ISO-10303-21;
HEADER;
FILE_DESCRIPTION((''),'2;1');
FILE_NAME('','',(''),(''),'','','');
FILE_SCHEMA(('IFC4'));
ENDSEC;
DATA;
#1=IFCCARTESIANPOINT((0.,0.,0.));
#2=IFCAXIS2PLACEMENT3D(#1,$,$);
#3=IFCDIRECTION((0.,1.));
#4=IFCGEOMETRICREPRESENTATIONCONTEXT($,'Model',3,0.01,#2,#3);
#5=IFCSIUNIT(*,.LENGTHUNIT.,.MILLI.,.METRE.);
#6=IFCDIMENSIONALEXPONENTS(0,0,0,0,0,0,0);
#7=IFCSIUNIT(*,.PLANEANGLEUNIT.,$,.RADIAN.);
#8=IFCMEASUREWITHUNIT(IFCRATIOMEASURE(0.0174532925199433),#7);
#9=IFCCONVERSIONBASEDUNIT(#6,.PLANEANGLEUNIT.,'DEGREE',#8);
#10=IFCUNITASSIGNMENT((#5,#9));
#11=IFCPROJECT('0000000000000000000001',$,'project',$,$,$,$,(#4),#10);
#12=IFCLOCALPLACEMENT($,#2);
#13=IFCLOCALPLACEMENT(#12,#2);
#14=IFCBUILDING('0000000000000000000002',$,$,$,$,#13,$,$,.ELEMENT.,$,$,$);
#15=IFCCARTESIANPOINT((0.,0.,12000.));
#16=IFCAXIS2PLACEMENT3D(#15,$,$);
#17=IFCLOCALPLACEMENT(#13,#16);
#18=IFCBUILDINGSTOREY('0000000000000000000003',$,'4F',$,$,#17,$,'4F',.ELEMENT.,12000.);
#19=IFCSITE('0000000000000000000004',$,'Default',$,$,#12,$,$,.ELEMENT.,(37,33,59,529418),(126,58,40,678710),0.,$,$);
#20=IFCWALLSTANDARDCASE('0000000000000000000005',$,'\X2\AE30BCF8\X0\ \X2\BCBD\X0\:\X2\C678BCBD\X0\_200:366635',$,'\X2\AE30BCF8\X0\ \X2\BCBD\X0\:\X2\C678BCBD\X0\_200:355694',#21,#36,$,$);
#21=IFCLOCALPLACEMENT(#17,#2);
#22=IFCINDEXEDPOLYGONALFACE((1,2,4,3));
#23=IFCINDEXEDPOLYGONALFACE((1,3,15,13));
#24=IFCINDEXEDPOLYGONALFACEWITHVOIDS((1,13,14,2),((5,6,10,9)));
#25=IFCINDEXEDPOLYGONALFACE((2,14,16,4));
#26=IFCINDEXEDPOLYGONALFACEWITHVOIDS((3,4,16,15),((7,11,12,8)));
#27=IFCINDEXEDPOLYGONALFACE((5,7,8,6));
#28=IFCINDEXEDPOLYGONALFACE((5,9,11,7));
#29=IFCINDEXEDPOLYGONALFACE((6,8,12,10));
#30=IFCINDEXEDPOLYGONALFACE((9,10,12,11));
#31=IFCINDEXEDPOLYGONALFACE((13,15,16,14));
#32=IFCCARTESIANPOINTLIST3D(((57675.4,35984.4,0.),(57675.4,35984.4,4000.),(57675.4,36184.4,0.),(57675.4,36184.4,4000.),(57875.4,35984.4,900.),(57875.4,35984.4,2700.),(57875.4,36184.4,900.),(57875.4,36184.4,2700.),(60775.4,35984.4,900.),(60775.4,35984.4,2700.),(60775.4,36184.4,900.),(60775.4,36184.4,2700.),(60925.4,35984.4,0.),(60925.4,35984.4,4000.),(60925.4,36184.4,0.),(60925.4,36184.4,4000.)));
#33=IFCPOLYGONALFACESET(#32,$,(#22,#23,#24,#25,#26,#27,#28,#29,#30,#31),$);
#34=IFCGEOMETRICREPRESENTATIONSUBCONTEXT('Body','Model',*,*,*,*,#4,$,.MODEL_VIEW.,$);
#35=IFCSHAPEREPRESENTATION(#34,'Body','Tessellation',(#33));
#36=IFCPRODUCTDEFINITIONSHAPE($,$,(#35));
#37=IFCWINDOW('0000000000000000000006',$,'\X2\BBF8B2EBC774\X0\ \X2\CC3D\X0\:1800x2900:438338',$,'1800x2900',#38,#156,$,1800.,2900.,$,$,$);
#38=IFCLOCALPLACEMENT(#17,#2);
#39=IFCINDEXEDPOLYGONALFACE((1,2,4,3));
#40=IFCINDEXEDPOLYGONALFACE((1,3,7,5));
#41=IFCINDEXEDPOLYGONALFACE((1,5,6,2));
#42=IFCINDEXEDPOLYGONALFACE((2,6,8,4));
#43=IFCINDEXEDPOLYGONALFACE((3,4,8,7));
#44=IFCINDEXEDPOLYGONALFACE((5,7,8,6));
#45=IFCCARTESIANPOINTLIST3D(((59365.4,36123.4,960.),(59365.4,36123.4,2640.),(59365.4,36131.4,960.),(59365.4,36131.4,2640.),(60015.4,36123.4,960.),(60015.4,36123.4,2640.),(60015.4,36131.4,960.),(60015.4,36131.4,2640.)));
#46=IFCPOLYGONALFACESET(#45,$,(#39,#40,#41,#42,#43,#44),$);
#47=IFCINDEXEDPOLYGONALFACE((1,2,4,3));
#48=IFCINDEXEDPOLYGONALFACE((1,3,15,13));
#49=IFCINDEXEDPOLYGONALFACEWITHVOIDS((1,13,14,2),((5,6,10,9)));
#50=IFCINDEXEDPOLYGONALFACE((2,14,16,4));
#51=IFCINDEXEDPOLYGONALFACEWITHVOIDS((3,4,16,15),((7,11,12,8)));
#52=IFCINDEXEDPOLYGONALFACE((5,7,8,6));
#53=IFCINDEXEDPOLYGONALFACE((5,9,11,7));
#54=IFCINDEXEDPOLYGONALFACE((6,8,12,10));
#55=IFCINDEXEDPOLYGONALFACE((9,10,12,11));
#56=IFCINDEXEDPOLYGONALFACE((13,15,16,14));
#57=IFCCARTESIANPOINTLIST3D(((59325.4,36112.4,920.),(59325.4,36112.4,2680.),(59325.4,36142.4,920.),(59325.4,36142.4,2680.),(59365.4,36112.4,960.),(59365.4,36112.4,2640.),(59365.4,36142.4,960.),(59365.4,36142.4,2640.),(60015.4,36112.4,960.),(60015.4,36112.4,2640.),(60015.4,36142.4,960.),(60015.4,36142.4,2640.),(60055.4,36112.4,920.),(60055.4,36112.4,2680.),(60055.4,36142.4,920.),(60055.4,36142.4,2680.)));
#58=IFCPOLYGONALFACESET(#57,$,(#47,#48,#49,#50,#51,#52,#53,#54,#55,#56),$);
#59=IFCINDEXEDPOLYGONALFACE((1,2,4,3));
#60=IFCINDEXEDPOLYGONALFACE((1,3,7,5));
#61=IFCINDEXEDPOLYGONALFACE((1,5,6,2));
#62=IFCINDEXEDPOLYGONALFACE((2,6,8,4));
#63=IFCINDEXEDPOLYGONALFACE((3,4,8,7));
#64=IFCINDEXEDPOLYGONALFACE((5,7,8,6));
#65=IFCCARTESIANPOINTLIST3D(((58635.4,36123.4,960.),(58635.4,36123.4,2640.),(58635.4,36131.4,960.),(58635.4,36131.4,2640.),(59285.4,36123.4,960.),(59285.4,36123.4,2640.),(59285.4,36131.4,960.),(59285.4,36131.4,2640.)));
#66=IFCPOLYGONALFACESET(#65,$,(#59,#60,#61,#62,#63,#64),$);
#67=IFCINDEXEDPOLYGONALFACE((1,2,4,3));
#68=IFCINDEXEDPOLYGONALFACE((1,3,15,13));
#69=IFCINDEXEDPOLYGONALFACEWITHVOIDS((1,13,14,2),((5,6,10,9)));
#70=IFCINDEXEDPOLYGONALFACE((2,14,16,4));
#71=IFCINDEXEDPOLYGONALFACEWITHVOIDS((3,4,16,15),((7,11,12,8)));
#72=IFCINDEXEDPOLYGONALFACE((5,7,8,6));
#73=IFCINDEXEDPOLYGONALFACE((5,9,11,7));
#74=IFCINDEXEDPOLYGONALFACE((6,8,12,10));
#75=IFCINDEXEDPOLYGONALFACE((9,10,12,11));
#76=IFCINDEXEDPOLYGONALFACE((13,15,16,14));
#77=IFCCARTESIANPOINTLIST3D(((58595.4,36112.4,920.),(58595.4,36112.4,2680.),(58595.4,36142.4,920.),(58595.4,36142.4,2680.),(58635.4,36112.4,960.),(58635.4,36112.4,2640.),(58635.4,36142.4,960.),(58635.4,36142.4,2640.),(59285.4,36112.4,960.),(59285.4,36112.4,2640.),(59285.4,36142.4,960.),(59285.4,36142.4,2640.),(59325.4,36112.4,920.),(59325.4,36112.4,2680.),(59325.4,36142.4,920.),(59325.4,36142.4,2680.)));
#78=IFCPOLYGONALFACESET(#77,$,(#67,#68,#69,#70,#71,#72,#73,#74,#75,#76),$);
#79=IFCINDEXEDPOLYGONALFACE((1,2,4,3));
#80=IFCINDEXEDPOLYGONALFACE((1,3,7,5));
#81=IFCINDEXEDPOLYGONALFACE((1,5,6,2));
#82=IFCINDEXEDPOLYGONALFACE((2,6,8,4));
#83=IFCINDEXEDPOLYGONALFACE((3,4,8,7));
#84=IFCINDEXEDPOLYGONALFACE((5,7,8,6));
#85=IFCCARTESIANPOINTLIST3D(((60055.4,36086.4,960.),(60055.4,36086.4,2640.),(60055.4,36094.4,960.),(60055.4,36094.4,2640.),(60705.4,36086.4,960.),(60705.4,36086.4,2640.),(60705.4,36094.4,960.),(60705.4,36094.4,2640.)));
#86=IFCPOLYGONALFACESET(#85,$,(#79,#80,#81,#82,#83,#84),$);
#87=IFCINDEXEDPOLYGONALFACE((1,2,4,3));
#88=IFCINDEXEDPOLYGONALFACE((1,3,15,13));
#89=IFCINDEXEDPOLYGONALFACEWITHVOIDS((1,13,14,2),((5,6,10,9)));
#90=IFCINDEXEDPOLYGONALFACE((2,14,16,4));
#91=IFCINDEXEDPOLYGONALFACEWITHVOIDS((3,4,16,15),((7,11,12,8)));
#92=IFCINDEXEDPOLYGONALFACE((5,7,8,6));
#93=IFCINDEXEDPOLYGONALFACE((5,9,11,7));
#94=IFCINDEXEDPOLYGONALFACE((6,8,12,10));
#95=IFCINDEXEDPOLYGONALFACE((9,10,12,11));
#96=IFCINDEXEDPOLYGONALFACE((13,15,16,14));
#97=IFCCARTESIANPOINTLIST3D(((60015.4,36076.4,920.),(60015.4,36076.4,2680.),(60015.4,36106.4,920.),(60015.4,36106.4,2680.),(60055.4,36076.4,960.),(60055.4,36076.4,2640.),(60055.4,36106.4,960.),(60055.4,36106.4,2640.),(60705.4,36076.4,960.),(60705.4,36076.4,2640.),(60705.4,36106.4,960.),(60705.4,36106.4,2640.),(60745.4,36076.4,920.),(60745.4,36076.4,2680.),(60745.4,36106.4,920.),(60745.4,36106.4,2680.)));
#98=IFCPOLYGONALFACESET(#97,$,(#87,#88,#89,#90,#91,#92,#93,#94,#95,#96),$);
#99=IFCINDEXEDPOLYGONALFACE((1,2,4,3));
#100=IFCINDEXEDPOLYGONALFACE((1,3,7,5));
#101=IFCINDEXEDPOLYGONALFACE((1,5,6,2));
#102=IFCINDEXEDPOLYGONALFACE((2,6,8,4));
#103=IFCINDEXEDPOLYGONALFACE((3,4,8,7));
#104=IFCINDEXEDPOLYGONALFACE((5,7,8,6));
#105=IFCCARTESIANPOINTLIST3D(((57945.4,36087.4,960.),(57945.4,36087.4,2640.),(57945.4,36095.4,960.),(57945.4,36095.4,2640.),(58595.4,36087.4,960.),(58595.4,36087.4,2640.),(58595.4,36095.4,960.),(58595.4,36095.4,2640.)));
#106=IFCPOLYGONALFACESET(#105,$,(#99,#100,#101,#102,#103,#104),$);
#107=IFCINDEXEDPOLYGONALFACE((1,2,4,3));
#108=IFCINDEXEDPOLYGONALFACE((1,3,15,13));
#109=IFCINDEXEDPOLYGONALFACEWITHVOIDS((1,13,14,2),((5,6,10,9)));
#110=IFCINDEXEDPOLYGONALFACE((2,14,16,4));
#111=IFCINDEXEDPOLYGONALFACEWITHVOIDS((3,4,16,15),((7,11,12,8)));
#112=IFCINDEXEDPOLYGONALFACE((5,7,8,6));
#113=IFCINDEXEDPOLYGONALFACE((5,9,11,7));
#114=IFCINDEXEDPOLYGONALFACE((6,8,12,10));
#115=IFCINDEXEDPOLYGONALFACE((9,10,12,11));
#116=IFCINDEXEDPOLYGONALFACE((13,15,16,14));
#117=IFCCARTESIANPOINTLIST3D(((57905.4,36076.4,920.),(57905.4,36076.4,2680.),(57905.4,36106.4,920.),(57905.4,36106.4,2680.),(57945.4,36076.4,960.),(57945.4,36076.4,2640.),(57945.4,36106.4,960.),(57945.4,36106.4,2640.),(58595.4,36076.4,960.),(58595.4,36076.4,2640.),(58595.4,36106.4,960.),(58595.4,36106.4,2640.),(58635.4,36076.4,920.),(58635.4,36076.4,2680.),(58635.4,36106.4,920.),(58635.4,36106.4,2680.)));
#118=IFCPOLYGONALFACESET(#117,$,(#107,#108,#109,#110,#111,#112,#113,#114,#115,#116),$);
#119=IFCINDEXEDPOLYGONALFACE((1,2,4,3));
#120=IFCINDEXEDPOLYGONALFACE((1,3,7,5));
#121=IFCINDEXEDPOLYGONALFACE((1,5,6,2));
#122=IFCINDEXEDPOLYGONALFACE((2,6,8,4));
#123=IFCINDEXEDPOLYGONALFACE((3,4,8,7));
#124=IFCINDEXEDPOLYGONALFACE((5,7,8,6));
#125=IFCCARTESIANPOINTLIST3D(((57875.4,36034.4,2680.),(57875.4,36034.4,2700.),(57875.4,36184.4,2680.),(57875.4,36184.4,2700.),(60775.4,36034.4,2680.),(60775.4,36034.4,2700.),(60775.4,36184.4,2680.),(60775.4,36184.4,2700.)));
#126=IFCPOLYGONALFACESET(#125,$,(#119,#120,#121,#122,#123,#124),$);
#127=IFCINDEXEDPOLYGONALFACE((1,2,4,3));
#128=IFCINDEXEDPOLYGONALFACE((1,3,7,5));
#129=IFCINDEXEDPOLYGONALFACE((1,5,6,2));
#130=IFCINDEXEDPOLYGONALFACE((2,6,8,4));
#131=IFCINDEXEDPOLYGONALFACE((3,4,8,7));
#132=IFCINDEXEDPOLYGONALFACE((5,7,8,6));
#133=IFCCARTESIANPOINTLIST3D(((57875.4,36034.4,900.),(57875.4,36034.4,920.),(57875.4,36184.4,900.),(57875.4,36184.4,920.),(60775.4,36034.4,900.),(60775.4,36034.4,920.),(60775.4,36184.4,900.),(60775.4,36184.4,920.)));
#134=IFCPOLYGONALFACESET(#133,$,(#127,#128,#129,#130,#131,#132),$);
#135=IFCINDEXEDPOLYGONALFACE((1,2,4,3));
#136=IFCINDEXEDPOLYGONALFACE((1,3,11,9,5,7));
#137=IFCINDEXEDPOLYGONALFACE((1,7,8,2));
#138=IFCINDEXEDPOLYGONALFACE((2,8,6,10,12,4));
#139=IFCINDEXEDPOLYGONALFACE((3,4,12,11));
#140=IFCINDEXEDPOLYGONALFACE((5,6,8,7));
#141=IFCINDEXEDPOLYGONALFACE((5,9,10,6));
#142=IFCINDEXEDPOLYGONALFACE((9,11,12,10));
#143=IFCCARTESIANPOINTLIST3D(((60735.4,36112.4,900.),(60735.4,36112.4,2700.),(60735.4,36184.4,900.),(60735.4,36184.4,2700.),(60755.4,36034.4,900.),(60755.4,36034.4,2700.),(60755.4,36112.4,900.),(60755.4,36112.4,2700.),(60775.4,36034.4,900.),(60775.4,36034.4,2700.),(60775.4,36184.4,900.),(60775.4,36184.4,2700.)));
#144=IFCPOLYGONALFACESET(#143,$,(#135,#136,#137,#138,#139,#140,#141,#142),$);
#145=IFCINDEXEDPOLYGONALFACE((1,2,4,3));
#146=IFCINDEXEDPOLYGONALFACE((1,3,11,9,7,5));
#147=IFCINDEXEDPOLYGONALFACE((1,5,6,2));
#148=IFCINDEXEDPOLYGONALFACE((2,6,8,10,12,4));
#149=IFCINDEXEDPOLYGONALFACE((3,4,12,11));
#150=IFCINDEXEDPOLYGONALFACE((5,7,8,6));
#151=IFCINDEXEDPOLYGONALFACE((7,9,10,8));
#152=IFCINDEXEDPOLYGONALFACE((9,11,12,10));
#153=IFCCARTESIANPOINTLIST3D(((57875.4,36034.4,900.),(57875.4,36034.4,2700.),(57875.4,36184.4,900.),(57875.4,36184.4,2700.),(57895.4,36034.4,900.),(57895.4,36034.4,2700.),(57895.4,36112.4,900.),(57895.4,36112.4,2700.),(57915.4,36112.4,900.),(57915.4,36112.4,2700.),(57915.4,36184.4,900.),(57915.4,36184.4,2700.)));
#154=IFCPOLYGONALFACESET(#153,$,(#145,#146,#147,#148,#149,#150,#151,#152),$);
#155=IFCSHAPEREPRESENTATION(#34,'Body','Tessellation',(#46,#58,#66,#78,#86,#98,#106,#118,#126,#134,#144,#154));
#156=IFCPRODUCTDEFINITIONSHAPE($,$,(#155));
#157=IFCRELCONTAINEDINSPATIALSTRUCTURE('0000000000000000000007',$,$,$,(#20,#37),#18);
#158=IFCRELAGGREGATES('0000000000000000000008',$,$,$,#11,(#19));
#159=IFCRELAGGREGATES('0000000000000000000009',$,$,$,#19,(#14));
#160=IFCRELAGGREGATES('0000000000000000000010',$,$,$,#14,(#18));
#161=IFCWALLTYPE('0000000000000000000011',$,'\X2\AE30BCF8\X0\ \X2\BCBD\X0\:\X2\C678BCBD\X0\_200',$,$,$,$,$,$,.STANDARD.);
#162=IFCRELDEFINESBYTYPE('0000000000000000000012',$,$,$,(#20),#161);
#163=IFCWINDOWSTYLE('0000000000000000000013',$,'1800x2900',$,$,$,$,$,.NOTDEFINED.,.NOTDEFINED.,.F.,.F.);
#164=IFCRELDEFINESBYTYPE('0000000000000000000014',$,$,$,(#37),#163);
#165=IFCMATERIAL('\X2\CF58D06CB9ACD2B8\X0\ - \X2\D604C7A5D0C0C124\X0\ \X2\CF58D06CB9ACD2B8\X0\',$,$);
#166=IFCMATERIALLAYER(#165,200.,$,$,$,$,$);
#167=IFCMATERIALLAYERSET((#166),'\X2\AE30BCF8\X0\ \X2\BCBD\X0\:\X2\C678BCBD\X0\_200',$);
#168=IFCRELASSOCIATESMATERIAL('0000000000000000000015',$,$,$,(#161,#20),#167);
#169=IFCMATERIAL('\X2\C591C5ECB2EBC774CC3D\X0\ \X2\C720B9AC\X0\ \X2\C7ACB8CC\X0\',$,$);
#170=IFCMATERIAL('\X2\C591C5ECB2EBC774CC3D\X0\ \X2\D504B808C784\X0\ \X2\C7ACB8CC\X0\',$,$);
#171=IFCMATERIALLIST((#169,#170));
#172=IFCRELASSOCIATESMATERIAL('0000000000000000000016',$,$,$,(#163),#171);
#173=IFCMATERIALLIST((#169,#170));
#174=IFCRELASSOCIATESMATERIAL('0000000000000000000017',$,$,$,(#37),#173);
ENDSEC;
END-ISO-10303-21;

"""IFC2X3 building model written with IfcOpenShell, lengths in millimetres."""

from ifc_helpers import new_model, entity, si_unit, converted_unit, direction, frame, frame_2d, origin, origin_2d_with_axis, place, context, subcontext, project, spatial, polyline, rectangle, outline, extrude, source, transform, mapped, material, material_list, layer, layer_set, layer_usage, type_object, type_shapes, element, fill, save


model = new_model("IFC2X3")

# Units and contexts
model_context = context("Model", 3, precision=0.01, world=origin(), true_north=direction((0.0, 1.0)))
body_context = subcontext(model_context, "Body", "Model", "MODEL_VIEW")
ifc_project = project(units=[si_unit("LENGTHUNIT", "METRE", prefix="MILLI"), converted_unit("PLANEANGLEUNIT", "DEGREE", entity("IfcRatioMeasure", 0.0174532925199433), si_unit("PLANEANGLEUNIT", "RADIAN"), dimensions=[0, 0, 0, 0, 0, 0, 0])], contexts=[model_context])

# Site, building, storey
site_placement = place(None, origin())
site = spatial("IfcSite", under=ifc_project, at=site_placement, Name="Default", CompositionType="ELEMENT", RefLatitude=(37, 33, 59, 529418), RefLongitude=(126, 58, 40, 678710), RefElevation=0.0)
building_placement = place(site_placement, origin())
building = spatial("IfcBuilding", under=site, at=building_placement, CompositionType="ELEMENT")
storey_placement = place(building_placement, frame((0.0, 0.0, 12000.0)))
storey = spatial("IfcBuildingStorey", under=building, at=storey_placement, Name="4F", LongName="4F", CompositionType="ELEMENT", Elevation=12000.0)

# Wall, opening, window
ifc_material_1 = material(Name="콘크리트 - 현장타설 콘크리트")
ifc_layer_1 = layer(ifc_material_1, 200.0)
ifc_layer_set_1 = layer_set([ifc_layer_1], Name="기본 벽:외벽_200")
wall_type_1 = type_object("IfcWallType", Name="기본 벽:외벽_200", PredefinedType="STANDARD", material=ifc_layer_set_1)
ifc_material_2 = material(Name="양여닫이창 유리 재료")
ifc_material_3 = material(Name="양여닫이창 프레임 재료")
ifc_material_list_1 = material_list([ifc_material_2, ifc_material_3])
window_style = type_object("IfcWindowStyle", Name="1800x2900", ConstructionType="NOTDEFINED", OperationType="NOTDEFINED", ParameterTakesPrecedence=False, Sizeable=False, material=ifc_material_list_1)
shared_shape_1 = source(origin(), body_context, "Body", "SweptSolid", [
    extrude(rectangle(XDim=8.0, YDim=650.0, at=frame_2d((0.0, 0.0), x_axis=(1.0, 0.0))), frame((1815.0, 143.0, 60.0), z_axis=(0.0, 0.0, 1.0), x_axis=(0.0, 1.0, 0.0)), (0.0, 0.0, 1.0), 1680.0),
    extrude(outline(polyline([(-880.0, -365.0), (880.0, -365.0), (880.0, 365.0), (-880.0, 365.0), (-880.0, -365.0)]), holes=[polyline([(840.0, -325.0), (-840.0, -325.0), (-840.0, 325.0), (840.0, 325.0), (840.0, -325.0)])]), frame((1815.0, 128.0, 900.0), z_axis=(0.0, 1.0, 0.0), x_axis=(0.0, 0.0, -1.0)), (0.0, 0.0, 1.0), 30.0),
    extrude(rectangle(XDim=8.0, YDim=650.0, at=frame_2d((0.0, 0.0), x_axis=(1.0, 0.0))), frame((1085.0, 143.0, 60.0), z_axis=(0.0, 0.0, 1.0), x_axis=(0.0, 1.0, 0.0)), (0.0, 0.0, 1.0), 1680.0),
    extrude(outline(polyline([(-880.0, -365.0), (880.0, -365.0), (880.0, 365.0), (-880.0, 365.0), (-880.0, -365.0)]), holes=[polyline([(840.0, -325.0), (-840.0, -325.0), (-840.0, 325.0), (840.0, 325.0), (840.0, -325.0)])]), frame((1085.0, 128.0, 900.0), z_axis=(0.0, 1.0, 0.0), x_axis=(0.0, 0.0, -1.0)), (0.0, 0.0, 1.0), 30.0),
    extrude(rectangle(XDim=8.0, YDim=650.0, at=frame_2d((0.0, 0.0), x_axis=(1.0, 0.0))), frame((2505.0, 106.0, 60.0), z_axis=(0.0, 0.0, 1.0), x_axis=(0.0, 1.0, 0.0)), (0.0, 0.0, 1.0), 1680.0),
    extrude(outline(polyline([(-880.0, -365.0), (880.0, -365.0), (880.0, 365.0), (-880.0, 365.0), (-880.0, -365.0)]), holes=[polyline([(840.0, -325.0), (-840.0, -325.0), (-840.0, 325.0), (840.0, 325.0), (840.0, -325.0)])]), frame((2505.0, 92.0, 900.0), z_axis=(0.0, 1.0, 0.0), x_axis=(0.0, 0.0, -1.0)), (0.0, 0.0, 1.0), 30.0),
    extrude(rectangle(XDim=8.0, YDim=650.0, at=origin_2d_with_axis()), frame((395.0, 107.0, 60.0), z_axis=(0.0, 0.0, 1.0), x_axis=(0.0, 1.0, 0.0)), (0.0, 0.0, 1.0), 1680.0),
    extrude(outline(polyline([(-880.0, -365.0), (880.0, -365.0), (880.0, 365.0), (-880.0, 365.0), (-880.0, -365.0)]), holes=[polyline([(840.0, -325.0), (-840.0, -325.0), (-840.0, 325.0), (840.0, 325.0), (840.0, -325.0)])]), frame((395.0, 92.0, 900.0), z_axis=(0.0, 1.0, 0.0), x_axis=(0.0, 0.0, -1.0)), (0.0, 0.0, 1.0), 30.0),
    extrude(rectangle(XDim=2900.0, YDim=150.0, at=origin_2d_with_axis()), frame((1450.0, 125.0, 1780.0), z_axis=(0.0, 0.0, 1.0), x_axis=(-1.0, 0.0, 0.0)), (0.0, 0.0, 1.0), 20.0),
    extrude(rectangle(XDim=2900.0, YDim=150.0, at=origin_2d_with_axis()), frame((1450.0, 125.0, 0.0), z_axis=(0.0, 0.0, 1.0), x_axis=(-1.0, 0.0, 0.0)), (0.0, 0.0, 1.0), 20.0),
    extrude(outline(polyline([(-74.0, -20.0), (-2.0, -20.0), (-2.0, 0.0), (76.0, 0.0), (76.0, 20.0), (-74.0, 20.0), (-74.0, -20.0)])), frame((2880.0, 126.0, 0.0), z_axis=(0.0, 0.0, 1.0), x_axis=(0.0, -1.0, 0.0)), (0.0, 0.0, 1.0), 1800.0),
    extrude(outline(polyline([(-20.0, -74.0), (20.0, -74.0), (20.0, 76.0), (0.0, 76.0), (0.0, -2.0), (-20.0, -2.0), (-20.0, -74.0)])), frame((20.0, 126.0, 0.0), z_axis=(0.0, 0.0, 1.0), x_axis=(-1.0, 0.0, 0.0)), (0.0, 0.0, 1.0), 1800.0),
])
type_shapes(window_style, [shared_shape_1])
ifc_layer_usage_1 = layer_usage(ifc_layer_set_1, "AXIS2", "NEGATIVE", 100.0)
wall_1_placement = place(storey_placement, frame((60925.4, 36084.4, 0.0), z_axis=(0.0, 0.0, 1.0), x_axis=(-1.0, 0.0, 0.0)))
wall_1 = element("IfcWallStandardCase", 1, at=wall_1_placement, inside=storey, type_object=wall_type_1, material=ifc_layer_usage_1, Name="기본 벽:외벽_200:366635", ObjectType="기본 벽:외벽_200:355694", context=body_context, shape_type="SweptSolid", body=[
    extrude(rectangle(XDim=3250.0, YDim=200.0, at=frame_2d((1625.0, 0.0), x_axis=(-1.0, 0.0))), origin(), (0.0, 0.0, 1.0), 4000.0),
])
opening_1_placement = place(wall_1_placement, frame((3050.0, 100.0, 900.0)))
opening_1 = element("IfcOpeningElement", 2, at=opening_1_placement, cuts=wall_1, ObjectType="Opening", context=body_context, shape_type="SweptSolid", body=[
    extrude(rectangle(XDim=1800.0, YDim=2900.0, at=frame_2d((900.0, 1450.0), x_axis=(1.0, 0.0))), frame((0.0, 0.0, 0.0), z_axis=(0.0, -1.0, 0.0), x_axis=(0.0, 0.0, 1.0)), (0.0, 0.0, 1.0), 200.0),
])
ifc_material_list_2 = material_list([ifc_material_2, ifc_material_3])
window_1_placement = place(opening_1_placement, frame((0.0, 0.0, 0.0), z_axis=(0.0, 0.0, 1.0), x_axis=(-1.0, 0.0, 0.0)))
window_1 = element("IfcWindow", 3, at=window_1_placement, inside=storey, type_object=window_style, material=ifc_material_list_2, Name="미닫이 창:1800x2900:438338", ObjectType="1800x2900", OverallHeight=1800.0, OverallWidth=2900.0, context=body_context, shape_type="MappedRepresentation", body=[
    mapped(shared_shape_1, transform((0.0, 0.0, 0.0), scale=1.0)),
])
fill(opening_1, window_1)

save(model, "model.ifc")
